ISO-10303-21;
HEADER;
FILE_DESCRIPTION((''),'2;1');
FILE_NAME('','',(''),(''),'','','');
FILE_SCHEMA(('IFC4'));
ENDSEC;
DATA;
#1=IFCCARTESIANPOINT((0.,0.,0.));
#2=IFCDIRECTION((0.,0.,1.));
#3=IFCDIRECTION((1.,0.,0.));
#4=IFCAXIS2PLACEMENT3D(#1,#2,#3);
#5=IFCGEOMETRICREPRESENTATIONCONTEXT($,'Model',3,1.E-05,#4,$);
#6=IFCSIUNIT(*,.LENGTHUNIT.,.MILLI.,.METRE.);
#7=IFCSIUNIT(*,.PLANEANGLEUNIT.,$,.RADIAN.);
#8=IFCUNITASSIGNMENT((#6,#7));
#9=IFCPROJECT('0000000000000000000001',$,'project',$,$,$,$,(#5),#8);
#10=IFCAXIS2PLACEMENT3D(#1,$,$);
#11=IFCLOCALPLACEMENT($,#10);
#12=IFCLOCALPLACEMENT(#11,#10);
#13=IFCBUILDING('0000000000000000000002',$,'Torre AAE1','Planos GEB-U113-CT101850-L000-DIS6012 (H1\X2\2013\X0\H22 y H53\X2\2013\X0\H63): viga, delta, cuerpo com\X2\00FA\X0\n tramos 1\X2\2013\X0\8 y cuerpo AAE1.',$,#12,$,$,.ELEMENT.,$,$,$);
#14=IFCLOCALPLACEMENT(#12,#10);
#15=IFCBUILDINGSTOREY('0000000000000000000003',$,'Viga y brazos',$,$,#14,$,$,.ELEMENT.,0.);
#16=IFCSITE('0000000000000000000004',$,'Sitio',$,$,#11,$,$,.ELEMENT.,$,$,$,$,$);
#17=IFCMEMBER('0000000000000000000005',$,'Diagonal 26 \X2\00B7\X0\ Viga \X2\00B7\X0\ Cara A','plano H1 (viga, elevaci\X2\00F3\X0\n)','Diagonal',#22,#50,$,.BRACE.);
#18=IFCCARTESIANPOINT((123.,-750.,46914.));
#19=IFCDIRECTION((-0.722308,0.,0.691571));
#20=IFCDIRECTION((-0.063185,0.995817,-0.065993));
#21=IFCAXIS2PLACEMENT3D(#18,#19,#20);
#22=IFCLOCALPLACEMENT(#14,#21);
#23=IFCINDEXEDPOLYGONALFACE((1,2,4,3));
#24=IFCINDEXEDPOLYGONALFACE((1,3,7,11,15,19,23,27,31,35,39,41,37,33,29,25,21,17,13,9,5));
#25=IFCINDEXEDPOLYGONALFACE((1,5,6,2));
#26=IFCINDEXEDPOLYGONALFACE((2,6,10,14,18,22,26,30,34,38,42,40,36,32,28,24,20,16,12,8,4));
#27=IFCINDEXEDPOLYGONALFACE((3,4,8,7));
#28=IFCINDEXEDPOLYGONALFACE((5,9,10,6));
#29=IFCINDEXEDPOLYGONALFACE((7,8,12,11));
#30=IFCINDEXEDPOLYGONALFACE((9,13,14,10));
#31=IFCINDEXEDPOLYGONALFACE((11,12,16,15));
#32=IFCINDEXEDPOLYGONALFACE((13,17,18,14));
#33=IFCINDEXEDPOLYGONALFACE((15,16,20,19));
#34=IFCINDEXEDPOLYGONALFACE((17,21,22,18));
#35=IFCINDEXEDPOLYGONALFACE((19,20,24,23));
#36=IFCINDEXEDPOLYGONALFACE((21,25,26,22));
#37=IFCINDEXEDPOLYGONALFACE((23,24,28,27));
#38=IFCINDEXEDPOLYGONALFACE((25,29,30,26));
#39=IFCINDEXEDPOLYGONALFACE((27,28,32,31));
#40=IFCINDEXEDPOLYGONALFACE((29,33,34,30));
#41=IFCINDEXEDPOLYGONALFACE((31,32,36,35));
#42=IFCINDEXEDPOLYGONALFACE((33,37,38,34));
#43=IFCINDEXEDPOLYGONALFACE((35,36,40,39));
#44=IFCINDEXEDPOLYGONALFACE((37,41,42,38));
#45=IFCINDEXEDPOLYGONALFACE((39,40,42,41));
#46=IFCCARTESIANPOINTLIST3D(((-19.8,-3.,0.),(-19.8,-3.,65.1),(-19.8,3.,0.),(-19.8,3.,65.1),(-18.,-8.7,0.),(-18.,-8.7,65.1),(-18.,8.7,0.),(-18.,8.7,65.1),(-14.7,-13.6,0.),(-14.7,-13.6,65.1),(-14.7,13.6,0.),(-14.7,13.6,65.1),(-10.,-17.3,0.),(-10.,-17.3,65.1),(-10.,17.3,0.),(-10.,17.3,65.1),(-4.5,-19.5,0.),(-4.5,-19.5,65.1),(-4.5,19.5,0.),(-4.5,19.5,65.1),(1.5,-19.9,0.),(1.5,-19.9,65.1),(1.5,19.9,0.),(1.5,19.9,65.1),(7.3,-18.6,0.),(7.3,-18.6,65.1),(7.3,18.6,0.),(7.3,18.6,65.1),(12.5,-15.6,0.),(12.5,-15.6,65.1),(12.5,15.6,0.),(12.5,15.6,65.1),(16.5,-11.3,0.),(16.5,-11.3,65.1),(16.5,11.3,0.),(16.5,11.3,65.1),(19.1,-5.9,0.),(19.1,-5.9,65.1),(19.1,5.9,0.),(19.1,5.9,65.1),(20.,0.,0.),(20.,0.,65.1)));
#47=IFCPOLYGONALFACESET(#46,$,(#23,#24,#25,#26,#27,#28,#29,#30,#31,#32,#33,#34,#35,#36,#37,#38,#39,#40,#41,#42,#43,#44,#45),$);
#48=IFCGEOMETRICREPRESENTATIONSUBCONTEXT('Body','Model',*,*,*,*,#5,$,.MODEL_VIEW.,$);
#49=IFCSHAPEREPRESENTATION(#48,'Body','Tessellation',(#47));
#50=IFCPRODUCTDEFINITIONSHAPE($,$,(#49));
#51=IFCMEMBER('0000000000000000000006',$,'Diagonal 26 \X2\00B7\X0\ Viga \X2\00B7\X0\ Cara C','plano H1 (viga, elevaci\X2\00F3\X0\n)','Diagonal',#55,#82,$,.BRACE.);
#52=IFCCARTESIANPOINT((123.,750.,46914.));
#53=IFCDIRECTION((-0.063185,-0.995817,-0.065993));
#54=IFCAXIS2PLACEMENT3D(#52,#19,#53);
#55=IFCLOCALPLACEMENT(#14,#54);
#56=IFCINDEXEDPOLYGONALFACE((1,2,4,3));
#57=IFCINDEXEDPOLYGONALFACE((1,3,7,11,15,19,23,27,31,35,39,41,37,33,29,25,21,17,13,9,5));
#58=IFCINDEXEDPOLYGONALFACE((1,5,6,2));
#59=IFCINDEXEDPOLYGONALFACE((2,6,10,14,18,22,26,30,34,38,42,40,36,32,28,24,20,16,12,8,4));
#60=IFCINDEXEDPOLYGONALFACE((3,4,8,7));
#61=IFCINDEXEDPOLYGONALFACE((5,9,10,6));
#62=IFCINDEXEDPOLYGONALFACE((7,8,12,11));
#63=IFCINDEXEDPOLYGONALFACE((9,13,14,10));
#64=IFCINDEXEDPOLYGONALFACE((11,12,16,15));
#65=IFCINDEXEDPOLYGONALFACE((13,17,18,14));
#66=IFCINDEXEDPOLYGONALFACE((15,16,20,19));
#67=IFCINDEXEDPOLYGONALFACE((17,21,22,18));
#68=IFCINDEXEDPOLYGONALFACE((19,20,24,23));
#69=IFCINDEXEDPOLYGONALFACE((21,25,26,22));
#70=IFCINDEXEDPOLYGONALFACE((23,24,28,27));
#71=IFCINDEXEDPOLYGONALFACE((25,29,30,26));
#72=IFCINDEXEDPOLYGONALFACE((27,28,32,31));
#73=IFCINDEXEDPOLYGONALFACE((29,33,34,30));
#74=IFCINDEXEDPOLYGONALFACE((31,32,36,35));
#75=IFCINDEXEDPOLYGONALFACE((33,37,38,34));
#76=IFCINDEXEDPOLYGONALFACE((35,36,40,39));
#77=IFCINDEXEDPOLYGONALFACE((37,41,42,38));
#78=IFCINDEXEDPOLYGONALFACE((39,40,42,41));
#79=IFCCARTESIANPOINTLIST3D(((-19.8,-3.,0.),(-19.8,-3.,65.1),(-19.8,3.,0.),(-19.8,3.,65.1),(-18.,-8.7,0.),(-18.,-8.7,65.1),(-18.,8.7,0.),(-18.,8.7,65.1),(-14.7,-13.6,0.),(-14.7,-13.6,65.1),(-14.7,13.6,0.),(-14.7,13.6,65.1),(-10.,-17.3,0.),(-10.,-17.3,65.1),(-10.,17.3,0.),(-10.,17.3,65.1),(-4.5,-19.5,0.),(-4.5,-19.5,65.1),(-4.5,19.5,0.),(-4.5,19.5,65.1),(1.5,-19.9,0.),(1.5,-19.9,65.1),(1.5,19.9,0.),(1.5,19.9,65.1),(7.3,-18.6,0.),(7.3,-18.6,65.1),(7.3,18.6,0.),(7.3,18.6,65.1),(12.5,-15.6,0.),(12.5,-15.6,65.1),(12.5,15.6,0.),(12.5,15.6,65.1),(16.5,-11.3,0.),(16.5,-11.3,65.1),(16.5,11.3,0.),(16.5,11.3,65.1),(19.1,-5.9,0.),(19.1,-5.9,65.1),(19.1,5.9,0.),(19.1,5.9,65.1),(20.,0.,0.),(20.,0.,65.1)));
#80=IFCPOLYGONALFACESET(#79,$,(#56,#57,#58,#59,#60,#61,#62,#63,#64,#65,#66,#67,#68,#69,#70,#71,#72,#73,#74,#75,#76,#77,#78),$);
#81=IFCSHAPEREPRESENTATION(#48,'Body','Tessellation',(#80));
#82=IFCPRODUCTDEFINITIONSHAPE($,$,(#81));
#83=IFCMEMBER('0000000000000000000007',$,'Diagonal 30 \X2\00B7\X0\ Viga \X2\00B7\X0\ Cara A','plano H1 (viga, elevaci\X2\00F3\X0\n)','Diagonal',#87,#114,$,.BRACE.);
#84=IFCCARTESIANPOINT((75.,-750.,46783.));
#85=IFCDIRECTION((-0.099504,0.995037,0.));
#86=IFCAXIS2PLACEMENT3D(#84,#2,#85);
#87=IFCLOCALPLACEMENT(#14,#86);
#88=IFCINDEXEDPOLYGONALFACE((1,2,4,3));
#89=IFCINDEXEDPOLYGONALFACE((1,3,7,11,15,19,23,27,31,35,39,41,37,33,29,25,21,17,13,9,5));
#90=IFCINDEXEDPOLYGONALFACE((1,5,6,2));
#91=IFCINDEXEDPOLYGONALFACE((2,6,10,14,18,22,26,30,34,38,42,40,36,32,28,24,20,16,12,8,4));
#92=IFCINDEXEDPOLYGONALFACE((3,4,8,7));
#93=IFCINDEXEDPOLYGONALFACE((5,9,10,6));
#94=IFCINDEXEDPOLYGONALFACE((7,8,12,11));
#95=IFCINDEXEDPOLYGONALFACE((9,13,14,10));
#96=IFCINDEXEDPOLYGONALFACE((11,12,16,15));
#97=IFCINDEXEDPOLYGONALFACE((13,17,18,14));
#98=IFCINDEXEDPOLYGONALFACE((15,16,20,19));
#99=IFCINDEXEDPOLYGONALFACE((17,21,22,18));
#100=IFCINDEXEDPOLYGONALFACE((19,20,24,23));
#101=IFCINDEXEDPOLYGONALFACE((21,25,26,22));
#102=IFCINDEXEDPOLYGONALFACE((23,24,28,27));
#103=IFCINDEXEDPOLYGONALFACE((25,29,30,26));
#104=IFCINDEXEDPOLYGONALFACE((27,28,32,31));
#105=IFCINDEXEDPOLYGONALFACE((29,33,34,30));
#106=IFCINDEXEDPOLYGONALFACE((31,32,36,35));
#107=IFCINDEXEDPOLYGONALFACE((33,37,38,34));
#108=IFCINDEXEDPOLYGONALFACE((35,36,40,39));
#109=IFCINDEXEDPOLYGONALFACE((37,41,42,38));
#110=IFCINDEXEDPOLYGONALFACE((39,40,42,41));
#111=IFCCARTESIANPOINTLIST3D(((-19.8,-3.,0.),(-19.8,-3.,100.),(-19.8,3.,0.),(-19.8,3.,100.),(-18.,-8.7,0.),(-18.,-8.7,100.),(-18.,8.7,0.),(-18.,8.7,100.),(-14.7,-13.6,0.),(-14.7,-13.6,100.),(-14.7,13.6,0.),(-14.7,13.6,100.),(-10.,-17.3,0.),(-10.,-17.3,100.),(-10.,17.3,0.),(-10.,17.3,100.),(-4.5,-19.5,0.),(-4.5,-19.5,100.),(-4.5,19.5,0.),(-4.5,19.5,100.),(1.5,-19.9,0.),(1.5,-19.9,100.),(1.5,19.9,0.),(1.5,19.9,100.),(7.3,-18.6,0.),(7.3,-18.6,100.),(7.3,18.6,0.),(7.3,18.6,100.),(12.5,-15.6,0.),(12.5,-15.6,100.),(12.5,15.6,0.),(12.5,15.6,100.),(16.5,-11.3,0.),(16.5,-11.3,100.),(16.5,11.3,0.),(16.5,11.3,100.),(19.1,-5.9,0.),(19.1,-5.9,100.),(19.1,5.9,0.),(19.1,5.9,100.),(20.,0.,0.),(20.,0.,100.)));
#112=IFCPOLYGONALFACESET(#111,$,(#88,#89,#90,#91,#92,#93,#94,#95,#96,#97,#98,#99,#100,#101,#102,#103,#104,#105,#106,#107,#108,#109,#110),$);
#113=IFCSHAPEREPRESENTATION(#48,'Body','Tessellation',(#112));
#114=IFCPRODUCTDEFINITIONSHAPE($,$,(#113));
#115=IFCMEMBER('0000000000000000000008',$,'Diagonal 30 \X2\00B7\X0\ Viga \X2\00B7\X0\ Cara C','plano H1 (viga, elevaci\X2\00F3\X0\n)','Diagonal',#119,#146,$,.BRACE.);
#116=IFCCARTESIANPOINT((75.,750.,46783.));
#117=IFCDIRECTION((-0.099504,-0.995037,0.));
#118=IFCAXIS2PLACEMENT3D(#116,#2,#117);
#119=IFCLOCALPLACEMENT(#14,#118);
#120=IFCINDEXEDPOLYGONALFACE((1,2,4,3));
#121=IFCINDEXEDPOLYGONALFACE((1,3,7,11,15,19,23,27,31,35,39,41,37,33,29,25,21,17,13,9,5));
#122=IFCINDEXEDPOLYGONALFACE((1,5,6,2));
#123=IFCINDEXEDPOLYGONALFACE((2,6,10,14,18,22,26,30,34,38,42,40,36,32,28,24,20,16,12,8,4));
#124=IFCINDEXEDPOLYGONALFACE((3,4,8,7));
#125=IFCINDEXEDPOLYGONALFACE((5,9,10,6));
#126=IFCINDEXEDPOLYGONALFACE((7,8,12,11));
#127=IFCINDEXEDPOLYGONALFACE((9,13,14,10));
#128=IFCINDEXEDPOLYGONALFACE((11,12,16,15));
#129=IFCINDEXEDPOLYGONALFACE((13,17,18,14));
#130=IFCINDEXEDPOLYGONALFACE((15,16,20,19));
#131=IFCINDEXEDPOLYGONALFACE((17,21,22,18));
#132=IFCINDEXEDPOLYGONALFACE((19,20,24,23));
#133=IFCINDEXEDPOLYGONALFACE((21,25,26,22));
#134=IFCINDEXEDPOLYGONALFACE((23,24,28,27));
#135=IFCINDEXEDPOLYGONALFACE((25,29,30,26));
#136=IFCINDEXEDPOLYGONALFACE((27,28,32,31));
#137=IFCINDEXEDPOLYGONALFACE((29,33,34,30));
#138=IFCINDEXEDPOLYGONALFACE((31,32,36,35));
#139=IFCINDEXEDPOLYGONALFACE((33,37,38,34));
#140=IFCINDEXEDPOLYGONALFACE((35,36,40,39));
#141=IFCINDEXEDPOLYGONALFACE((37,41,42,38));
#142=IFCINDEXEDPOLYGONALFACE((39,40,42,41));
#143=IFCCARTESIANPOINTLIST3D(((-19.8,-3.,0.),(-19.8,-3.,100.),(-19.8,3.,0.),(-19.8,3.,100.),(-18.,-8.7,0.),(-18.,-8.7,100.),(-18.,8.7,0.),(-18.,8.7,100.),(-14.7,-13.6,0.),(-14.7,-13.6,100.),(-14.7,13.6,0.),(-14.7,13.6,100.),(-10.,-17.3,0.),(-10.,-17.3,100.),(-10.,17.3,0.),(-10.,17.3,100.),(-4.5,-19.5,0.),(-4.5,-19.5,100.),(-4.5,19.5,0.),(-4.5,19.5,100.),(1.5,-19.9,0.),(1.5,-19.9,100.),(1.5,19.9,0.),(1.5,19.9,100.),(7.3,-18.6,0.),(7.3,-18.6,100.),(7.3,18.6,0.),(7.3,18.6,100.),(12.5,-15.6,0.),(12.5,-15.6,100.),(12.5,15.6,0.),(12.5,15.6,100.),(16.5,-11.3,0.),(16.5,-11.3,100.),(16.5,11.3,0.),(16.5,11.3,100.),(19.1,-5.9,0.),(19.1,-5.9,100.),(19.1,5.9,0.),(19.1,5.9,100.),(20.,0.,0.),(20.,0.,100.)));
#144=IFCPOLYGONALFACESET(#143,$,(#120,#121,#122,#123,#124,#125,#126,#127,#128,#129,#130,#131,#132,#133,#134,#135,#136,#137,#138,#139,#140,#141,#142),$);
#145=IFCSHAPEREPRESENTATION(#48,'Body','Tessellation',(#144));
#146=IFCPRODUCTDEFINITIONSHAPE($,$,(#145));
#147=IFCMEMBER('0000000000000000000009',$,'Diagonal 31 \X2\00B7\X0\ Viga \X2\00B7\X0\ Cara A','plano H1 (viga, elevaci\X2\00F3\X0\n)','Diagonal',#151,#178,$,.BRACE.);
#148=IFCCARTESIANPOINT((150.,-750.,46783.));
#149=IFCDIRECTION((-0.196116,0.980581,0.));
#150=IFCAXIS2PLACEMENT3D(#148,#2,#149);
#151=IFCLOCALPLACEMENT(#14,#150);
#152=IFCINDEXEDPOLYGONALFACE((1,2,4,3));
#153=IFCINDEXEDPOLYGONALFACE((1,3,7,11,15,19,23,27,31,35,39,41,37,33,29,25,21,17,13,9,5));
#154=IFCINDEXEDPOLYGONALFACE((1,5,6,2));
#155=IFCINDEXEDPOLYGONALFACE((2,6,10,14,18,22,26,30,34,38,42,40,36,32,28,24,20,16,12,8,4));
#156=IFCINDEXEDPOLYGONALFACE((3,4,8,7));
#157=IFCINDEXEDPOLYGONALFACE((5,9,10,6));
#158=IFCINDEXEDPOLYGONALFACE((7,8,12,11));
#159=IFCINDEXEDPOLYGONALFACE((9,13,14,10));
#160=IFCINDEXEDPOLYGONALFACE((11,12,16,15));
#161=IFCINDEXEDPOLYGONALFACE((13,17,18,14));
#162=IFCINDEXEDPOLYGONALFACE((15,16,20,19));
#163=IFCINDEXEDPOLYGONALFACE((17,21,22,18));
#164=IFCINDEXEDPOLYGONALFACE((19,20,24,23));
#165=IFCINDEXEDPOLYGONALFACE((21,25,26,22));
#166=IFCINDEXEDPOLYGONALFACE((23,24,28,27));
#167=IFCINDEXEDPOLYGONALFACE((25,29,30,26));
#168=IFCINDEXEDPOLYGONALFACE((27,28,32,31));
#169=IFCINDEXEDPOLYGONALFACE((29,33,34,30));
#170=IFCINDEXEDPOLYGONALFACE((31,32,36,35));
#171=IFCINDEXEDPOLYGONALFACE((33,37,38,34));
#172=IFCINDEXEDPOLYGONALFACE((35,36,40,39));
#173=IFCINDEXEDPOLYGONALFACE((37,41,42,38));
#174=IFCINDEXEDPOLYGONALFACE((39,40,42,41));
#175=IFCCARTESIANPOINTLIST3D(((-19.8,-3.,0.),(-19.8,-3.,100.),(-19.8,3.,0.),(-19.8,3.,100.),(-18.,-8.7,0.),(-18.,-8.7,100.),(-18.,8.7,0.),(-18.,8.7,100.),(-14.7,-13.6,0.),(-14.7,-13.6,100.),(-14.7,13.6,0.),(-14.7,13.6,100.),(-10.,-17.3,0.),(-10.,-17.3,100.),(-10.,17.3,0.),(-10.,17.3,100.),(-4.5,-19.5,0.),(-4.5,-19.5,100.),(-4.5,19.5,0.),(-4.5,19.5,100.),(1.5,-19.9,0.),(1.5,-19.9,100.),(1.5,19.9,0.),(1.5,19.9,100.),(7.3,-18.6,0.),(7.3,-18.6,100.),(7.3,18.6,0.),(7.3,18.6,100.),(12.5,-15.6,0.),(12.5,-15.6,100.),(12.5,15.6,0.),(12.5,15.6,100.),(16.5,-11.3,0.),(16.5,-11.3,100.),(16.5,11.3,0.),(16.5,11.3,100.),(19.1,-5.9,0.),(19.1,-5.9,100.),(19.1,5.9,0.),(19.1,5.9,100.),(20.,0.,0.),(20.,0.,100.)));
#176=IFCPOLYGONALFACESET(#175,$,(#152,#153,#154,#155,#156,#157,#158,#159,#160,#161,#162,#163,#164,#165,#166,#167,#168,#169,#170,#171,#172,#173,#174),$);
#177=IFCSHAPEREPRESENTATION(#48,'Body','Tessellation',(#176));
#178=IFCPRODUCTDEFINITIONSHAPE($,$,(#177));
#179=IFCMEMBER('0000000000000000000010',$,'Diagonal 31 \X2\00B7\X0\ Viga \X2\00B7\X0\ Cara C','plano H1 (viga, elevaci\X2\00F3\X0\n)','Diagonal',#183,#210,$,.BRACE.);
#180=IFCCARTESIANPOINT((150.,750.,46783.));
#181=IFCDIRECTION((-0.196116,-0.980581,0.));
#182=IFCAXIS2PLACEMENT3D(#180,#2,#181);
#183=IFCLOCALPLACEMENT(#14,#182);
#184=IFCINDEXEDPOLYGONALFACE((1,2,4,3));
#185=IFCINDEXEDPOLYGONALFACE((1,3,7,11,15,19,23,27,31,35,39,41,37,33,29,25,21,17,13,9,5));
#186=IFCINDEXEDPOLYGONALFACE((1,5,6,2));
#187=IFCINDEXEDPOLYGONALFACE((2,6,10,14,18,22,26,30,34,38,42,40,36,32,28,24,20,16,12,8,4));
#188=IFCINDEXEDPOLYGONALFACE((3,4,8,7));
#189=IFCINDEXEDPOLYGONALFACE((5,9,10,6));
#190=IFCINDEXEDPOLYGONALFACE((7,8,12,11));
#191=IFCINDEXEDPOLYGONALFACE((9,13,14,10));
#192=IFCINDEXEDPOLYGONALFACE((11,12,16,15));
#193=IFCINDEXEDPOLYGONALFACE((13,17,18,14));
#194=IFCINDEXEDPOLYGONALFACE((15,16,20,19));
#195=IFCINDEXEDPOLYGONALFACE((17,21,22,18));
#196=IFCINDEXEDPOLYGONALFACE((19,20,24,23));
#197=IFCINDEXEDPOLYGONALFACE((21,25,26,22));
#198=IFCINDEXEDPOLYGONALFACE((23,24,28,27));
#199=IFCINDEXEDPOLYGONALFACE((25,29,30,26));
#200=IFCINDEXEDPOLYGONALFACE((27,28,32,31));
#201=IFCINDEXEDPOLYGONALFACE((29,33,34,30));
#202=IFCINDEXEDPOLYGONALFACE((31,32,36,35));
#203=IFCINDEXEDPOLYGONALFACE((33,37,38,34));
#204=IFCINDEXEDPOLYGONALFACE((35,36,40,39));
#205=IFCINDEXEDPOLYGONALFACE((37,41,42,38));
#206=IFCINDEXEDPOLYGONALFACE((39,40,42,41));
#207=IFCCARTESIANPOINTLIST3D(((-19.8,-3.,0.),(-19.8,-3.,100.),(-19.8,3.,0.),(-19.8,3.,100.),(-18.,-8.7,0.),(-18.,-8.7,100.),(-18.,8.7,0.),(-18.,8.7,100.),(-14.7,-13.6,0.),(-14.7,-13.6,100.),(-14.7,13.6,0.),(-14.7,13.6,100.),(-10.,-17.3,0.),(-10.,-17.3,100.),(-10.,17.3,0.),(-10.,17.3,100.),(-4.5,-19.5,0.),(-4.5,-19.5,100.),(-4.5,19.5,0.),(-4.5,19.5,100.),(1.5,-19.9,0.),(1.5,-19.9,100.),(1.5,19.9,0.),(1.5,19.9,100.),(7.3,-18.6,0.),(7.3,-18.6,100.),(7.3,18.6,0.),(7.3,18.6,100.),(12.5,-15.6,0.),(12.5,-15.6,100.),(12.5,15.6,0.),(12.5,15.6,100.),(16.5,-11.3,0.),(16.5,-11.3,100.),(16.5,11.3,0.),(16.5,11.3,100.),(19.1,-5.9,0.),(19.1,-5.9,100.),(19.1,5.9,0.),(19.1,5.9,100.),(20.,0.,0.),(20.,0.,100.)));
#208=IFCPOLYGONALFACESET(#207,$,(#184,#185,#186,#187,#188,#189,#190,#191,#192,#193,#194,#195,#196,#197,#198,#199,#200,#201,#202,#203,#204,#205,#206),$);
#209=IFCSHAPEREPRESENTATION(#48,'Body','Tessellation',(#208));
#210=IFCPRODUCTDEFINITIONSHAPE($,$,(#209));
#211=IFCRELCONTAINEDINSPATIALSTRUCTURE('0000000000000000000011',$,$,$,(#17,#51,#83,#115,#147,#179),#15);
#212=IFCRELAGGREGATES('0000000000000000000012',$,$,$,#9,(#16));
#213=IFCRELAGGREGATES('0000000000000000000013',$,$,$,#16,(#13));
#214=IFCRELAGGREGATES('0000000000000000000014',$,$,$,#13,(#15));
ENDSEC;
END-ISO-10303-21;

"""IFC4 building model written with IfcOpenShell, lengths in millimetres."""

from ifc_helpers import new_model, si_unit, frame, origin, origin_with_axes, place, context, subcontext, project, spatial, circle, extrude, element, save


model = new_model("IFC4")

# Units and contexts
model_context = context("Model", 3, precision=1e-05, world=origin_with_axes())
body_context = subcontext(model_context, "Body", "Model", "MODEL_VIEW")
ifc_project = project(units=[si_unit("LENGTHUNIT", "METRE", prefix="MILLI"), si_unit("PLANEANGLEUNIT", "RADIAN")], contexts=[model_context])

# Site, building, storey
site_placement = place(None, origin())
site = spatial("IfcSite", under=ifc_project, at=site_placement, Name="Sitio", CompositionType="ELEMENT")
building_placement = place(site_placement, origin())
building = spatial("IfcBuilding", under=site, at=building_placement, Name="Torre AAE1", Description="Planos GEB-U113-CT101850-L000-DIS6012 (H1–H22 y H53–H63): viga, delta, cuerpo común tramos 1–8 y cuerpo AAE1.", CompositionType="ELEMENT")
storey_placement = place(building_placement, origin())
storey = spatial("IfcBuildingStorey", under=building, at=storey_placement, Name="Viga y brazos", CompositionType="ELEMENT", Elevation=0.0)

# Members
for number, where, z_axis, x_axis, name in (
    (1, (123.0, -750.0, 46914.0), (-0.722308, 0.0, 0.691571), (-0.063185, 0.995817, -0.065993), "Diagonal 26 · Viga · Cara A"),
    (2, (123.0, 750.0, 46914.0), (-0.722308, 0.0, 0.691571), (-0.063185, -0.995817, -0.065993), "Diagonal 26 · Viga · Cara C"),
):
    element("IfcMember", number, at=place(storey_placement, frame(where, z_axis=z_axis, x_axis=x_axis)), inside=storey, Name=name, Description="plano H1 (viga, elevación)", ObjectType="Diagonal", PredefinedType="BRACE", context=body_context, shape_type="SweptSolid", body=[
        extrude(circle(Radius=20.0), None, (0.0, 0.0, 1.0), 65.1),
    ])
for number, where, z_axis, x_axis, name in (
    (3, (75.0, -750.0, 46783.0), (0.0, 0.0, 1.0), (-0.099504, 0.995037, 0.0), "Diagonal 30 · Viga · Cara A"),
    (4, (75.0, 750.0, 46783.0), (0.0, 0.0, 1.0), (-0.099504, -0.995037, 0.0), "Diagonal 30 · Viga · Cara C"),
    (5, (150.0, -750.0, 46783.0), (0.0, 0.0, 1.0), (-0.196116, 0.980581, 0.0), "Diagonal 31 · Viga · Cara A"),
    (6, (150.0, 750.0, 46783.0), (0.0, 0.0, 1.0), (-0.196116, -0.980581, 0.0), "Diagonal 31 · Viga · Cara C"),
):
    element("IfcMember", number, at=place(storey_placement, frame(where, z_axis=z_axis, x_axis=x_axis)), inside=storey, Name=name, Description="plano H1 (viga, elevación)", ObjectType="Diagonal", PredefinedType="BRACE", context=body_context, shape_type="SweptSolid", body=[
        extrude(circle(Radius=20.0), None, (0.0, 0.0, 1.0), 100.0),
    ])

save(model, "model.ifc")
